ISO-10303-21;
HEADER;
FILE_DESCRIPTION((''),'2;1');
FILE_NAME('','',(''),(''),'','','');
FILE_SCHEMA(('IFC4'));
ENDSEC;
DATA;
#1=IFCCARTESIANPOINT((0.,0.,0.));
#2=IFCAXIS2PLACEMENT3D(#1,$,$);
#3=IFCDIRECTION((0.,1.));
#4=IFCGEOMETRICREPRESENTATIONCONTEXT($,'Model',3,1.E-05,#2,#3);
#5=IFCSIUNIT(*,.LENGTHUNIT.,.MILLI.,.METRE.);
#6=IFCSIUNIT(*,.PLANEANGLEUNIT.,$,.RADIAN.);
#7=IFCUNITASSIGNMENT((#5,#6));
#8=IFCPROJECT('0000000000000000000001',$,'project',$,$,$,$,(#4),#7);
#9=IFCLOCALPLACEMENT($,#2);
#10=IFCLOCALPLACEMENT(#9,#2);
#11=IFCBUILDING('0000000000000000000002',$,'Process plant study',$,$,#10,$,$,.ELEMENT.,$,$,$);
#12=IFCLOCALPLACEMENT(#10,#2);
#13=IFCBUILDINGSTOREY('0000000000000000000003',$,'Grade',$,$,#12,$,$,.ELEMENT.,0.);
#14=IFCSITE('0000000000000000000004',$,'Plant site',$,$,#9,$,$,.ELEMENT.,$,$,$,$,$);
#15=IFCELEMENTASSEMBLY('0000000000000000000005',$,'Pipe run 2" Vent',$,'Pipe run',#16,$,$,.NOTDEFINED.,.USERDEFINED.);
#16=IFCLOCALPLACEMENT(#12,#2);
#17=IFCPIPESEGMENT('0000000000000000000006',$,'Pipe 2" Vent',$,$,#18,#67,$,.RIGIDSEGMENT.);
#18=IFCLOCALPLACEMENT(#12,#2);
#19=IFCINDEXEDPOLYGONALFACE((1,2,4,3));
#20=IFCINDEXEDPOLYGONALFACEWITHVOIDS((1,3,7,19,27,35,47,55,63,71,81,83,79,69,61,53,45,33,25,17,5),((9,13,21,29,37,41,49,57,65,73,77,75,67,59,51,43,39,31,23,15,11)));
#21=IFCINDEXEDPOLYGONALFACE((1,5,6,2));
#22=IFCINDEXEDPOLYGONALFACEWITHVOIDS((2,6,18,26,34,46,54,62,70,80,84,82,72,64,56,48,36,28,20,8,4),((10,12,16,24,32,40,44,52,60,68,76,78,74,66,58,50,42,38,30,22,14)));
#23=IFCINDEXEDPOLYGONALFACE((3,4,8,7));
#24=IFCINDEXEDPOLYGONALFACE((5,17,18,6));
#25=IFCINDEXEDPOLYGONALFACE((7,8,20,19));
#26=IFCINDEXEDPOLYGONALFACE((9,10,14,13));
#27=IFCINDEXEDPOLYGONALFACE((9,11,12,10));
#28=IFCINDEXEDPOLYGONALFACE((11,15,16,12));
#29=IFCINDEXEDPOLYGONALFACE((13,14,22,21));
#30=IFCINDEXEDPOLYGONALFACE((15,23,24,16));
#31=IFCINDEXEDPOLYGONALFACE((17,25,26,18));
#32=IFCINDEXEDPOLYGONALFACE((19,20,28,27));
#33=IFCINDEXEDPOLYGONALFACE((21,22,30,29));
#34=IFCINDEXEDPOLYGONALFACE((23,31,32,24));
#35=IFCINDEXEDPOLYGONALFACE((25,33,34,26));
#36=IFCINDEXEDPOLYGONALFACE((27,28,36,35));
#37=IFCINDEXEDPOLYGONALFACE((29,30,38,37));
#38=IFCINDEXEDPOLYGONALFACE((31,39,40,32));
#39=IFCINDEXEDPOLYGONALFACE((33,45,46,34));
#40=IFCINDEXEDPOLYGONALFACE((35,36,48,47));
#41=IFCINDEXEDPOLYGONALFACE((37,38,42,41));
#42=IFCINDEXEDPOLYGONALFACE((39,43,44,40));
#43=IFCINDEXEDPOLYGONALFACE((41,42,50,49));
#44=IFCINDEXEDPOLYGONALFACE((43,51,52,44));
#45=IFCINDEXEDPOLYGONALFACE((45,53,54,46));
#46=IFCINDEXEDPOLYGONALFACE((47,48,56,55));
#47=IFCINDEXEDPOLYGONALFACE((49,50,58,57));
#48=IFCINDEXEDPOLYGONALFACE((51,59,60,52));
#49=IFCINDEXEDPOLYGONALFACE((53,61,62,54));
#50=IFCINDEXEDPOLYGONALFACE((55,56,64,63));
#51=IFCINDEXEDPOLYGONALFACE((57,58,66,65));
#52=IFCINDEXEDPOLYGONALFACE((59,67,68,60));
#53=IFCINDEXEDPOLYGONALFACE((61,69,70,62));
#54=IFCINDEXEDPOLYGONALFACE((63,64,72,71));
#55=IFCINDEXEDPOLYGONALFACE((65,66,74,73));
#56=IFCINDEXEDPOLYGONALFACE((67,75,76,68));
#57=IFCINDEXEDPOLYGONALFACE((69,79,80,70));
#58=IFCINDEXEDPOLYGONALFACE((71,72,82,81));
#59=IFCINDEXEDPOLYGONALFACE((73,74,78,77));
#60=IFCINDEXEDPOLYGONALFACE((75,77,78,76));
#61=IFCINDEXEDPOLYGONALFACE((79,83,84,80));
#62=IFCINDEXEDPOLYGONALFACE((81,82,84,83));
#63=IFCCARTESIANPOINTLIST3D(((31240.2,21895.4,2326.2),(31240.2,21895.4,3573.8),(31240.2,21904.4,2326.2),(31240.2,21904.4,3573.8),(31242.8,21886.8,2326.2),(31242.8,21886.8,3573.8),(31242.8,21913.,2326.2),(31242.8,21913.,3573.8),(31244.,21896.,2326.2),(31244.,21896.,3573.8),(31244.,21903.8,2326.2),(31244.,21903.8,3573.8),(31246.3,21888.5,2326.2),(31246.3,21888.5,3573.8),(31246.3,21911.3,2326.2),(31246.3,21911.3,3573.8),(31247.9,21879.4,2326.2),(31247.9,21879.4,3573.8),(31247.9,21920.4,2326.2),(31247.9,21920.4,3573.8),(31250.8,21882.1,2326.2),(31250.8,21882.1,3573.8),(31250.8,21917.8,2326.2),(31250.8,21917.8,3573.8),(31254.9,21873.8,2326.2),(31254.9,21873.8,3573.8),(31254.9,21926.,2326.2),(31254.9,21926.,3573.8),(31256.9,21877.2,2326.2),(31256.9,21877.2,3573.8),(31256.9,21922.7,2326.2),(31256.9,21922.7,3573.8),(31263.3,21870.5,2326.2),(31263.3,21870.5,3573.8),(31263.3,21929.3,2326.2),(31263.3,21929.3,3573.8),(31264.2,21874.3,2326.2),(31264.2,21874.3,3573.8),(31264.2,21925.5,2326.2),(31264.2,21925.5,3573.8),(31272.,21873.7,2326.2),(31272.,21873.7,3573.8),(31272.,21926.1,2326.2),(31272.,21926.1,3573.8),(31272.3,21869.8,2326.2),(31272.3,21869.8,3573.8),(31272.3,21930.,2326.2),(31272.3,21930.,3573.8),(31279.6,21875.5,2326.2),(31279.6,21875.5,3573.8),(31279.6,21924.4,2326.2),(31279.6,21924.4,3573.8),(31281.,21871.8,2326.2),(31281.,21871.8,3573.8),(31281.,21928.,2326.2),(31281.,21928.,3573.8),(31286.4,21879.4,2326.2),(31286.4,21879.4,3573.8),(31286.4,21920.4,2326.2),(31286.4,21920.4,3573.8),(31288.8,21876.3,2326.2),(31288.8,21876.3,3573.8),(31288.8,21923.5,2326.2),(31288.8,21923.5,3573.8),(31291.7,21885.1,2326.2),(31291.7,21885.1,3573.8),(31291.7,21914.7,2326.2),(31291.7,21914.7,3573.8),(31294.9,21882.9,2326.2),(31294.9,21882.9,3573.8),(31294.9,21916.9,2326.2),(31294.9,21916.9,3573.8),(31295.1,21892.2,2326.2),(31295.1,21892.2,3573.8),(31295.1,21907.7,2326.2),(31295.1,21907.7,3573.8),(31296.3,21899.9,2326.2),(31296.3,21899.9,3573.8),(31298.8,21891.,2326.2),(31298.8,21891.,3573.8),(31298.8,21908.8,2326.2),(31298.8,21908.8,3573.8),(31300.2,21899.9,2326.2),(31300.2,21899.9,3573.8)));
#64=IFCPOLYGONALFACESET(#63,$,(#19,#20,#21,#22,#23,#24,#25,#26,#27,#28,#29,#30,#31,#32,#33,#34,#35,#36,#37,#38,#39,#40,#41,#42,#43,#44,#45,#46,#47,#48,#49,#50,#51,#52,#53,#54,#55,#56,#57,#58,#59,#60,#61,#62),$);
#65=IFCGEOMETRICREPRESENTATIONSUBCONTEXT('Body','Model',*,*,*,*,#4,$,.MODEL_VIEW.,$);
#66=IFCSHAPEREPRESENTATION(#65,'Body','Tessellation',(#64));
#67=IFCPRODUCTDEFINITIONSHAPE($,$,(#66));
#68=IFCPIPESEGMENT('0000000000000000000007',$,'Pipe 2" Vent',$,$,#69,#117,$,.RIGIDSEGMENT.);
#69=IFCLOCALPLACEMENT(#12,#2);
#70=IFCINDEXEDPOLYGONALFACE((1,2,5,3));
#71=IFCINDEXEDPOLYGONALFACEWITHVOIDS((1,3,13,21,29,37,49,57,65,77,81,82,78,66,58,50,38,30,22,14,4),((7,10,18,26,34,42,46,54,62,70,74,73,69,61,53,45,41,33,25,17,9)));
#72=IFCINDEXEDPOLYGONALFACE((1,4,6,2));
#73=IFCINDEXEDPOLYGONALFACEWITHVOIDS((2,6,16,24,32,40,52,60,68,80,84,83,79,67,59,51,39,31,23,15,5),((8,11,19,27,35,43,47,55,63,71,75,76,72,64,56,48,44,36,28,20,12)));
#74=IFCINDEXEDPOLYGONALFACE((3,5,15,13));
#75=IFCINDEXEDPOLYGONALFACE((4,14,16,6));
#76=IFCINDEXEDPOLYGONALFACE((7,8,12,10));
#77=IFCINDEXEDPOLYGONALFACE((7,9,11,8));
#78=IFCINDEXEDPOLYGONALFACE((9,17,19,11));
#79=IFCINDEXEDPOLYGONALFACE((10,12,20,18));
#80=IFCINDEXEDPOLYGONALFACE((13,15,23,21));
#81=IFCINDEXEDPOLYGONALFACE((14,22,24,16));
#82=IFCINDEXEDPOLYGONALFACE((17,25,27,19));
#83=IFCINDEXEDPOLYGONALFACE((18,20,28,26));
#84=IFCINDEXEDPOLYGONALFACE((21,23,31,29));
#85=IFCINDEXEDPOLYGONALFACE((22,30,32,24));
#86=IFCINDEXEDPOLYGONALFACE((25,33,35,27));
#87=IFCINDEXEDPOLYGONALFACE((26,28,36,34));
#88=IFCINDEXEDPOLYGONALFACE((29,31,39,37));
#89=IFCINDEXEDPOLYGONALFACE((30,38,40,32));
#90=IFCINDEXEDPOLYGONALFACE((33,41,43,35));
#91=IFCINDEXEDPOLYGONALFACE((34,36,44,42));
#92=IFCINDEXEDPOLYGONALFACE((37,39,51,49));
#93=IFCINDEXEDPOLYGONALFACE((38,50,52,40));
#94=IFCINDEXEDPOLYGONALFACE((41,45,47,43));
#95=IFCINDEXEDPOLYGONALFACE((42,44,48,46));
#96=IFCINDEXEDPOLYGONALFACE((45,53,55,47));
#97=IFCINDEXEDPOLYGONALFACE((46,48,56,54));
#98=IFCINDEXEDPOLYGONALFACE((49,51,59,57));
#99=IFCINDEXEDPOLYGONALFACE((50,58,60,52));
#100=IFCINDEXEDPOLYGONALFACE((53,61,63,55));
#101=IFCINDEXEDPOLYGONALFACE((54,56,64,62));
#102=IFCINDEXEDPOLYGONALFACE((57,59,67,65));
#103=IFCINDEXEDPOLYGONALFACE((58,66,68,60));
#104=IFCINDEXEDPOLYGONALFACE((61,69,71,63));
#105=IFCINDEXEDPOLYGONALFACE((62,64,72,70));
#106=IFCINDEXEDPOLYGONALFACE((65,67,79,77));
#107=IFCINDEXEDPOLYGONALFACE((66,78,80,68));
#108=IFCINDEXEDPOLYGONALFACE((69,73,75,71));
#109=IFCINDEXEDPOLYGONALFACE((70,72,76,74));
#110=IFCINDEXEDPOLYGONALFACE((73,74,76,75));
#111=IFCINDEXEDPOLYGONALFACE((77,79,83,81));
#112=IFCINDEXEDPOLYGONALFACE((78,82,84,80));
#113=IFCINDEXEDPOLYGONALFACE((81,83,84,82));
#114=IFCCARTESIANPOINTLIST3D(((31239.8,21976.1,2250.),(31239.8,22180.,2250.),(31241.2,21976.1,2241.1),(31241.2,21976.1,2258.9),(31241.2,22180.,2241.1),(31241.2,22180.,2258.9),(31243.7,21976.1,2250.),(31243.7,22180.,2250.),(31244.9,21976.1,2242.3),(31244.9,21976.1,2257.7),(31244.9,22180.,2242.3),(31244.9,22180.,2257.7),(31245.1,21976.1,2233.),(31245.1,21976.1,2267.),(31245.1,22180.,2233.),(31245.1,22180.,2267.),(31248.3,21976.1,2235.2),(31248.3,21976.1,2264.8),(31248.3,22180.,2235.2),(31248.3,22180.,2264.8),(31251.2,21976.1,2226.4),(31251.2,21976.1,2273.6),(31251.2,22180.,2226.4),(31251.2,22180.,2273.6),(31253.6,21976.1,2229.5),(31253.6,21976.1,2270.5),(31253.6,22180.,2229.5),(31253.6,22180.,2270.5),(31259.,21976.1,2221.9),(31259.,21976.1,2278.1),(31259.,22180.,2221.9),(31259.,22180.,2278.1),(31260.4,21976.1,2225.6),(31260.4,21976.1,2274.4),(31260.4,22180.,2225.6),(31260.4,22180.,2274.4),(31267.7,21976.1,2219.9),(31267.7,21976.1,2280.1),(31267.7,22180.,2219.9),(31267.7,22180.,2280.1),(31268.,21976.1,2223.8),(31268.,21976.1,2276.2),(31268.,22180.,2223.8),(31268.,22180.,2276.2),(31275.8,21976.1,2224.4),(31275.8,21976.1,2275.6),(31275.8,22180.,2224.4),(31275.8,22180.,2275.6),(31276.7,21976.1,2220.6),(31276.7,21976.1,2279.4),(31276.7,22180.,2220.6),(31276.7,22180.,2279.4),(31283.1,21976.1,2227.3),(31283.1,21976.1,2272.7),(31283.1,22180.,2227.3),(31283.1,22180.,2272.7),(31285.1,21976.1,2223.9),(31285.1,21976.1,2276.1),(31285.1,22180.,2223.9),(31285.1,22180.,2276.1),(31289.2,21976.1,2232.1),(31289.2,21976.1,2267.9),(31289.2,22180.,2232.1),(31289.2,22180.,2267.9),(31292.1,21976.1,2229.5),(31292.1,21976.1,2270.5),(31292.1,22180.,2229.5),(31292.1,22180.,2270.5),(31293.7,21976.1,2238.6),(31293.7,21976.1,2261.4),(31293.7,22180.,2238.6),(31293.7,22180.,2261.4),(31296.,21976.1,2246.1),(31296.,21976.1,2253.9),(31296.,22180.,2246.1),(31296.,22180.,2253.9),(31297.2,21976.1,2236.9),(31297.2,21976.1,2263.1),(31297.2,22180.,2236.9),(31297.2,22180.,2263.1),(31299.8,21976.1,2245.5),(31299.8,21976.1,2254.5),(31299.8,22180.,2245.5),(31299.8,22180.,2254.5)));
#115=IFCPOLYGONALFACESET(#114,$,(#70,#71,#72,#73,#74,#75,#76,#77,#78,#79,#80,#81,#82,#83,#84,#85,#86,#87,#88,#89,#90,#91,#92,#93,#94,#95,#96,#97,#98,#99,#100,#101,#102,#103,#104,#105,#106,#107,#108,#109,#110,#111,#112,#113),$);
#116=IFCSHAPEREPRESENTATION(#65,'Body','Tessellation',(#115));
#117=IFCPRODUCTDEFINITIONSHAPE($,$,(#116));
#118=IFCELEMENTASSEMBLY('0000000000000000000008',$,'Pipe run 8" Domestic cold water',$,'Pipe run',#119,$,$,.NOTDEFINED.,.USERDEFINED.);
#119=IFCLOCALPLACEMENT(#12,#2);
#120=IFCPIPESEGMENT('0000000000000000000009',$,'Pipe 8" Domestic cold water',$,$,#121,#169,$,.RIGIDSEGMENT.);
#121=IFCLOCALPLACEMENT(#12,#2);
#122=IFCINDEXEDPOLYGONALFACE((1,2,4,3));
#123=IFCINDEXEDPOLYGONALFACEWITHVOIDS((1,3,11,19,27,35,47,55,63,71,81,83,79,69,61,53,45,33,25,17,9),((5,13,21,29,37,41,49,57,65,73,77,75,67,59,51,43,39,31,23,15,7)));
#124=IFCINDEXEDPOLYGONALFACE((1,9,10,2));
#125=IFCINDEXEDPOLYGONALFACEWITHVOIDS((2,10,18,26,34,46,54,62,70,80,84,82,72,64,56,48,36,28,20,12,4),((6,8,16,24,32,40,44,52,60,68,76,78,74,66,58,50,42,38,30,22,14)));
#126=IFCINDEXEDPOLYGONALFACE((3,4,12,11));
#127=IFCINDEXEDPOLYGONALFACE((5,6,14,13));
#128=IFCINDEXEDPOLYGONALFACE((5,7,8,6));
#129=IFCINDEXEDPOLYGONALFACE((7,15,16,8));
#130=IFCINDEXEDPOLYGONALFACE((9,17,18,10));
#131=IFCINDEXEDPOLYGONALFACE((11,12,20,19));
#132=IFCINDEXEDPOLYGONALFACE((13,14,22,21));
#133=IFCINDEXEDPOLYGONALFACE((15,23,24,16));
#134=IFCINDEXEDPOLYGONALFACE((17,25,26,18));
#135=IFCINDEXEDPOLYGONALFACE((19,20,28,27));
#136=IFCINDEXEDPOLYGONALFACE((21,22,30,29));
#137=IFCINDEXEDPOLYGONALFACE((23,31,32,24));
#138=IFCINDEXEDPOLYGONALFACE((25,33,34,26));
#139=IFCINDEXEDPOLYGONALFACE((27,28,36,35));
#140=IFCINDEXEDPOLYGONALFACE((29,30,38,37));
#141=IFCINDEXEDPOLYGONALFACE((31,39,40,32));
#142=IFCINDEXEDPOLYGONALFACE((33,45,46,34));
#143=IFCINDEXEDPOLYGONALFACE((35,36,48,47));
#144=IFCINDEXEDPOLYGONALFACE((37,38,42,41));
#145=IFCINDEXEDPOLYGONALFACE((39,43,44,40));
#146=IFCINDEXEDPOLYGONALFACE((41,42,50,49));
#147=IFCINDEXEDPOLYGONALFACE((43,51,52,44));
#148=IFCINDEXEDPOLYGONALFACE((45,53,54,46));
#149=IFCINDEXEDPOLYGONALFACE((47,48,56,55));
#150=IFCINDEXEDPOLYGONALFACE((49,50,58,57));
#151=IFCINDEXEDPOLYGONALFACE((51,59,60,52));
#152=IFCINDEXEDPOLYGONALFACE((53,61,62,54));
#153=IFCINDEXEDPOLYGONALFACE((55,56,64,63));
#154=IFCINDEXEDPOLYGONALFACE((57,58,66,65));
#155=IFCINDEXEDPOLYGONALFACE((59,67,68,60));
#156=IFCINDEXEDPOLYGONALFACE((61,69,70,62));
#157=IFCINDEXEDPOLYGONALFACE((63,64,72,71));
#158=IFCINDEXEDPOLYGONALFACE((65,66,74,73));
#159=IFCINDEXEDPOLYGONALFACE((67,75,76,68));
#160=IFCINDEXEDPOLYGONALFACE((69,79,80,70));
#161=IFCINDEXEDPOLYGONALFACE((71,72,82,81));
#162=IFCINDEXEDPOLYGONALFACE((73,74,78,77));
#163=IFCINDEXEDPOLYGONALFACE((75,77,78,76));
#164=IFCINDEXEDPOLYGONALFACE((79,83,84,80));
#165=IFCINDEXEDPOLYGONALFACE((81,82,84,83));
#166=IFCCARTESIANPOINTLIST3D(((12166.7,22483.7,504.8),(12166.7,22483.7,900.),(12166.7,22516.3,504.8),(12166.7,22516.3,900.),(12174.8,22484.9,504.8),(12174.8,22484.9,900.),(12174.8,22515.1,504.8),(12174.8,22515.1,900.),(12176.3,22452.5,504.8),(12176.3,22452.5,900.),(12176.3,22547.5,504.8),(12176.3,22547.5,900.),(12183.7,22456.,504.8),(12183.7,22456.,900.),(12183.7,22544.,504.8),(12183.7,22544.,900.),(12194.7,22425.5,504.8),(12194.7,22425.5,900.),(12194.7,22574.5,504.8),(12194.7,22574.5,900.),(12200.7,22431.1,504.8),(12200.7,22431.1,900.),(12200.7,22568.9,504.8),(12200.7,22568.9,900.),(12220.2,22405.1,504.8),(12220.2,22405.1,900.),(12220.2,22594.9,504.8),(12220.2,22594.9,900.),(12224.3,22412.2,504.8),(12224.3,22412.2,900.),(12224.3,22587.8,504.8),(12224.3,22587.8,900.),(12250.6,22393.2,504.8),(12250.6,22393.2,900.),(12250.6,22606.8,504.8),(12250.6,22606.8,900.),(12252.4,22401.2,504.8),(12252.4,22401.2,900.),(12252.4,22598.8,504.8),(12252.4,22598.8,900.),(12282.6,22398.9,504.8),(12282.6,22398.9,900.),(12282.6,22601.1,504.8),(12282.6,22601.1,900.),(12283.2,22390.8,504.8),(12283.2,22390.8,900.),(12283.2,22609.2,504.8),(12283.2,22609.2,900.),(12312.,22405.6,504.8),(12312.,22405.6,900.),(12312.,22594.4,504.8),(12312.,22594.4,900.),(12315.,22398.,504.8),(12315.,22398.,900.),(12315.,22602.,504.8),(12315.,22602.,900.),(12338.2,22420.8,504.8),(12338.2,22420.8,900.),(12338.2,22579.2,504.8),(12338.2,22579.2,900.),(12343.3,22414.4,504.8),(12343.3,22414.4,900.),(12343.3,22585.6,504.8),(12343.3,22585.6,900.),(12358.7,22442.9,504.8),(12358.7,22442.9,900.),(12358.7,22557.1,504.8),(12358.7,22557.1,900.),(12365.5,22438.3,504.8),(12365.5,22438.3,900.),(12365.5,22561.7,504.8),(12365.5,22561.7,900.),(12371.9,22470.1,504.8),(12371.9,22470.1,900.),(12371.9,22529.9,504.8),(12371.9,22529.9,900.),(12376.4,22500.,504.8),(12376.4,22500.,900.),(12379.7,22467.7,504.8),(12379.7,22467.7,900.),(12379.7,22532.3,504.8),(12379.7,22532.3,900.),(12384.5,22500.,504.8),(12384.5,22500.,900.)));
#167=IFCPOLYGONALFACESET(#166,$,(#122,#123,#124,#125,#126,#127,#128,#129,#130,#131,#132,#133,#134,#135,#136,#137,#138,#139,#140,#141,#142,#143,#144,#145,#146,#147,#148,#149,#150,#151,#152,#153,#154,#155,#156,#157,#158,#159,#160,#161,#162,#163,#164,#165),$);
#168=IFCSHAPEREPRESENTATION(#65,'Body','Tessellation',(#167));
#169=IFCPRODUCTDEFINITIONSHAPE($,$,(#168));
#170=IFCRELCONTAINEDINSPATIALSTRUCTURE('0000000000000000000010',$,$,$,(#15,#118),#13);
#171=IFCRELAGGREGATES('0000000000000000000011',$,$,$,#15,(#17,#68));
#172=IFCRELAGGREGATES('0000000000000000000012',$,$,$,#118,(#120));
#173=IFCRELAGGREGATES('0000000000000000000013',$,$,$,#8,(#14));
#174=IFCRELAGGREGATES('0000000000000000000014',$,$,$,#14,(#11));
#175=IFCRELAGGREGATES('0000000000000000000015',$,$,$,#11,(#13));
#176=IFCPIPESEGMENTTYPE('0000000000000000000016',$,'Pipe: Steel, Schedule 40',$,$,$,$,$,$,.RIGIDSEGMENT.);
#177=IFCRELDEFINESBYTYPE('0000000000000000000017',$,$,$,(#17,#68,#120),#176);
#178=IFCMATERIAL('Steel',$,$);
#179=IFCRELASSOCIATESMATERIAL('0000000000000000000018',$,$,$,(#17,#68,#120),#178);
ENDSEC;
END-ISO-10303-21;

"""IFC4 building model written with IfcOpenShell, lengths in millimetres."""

from ifc_helpers import new_model, si_unit, direction, frame, origin, origin_with_axes, origin_2d, place, context, subcontext, project, spatial, hollow_circle, extrude, material, type_object, element, aggregate, save


model = new_model("IFC4")

# Units and contexts
model_context = context("Model", 3, precision=1e-05, world=origin(), true_north=direction((0.0, 1.0)))
body_context = subcontext(model_context, "Body", "Model", "MODEL_VIEW")
ifc_project = project(units=[si_unit("LENGTHUNIT", "METRE", prefix="MILLI"), si_unit("PLANEANGLEUNIT", "RADIAN")], contexts=[model_context])

# Site, building, storey
site_placement = place(None, origin())
site = spatial("IfcSite", under=ifc_project, at=site_placement, Name="Plant site", CompositionType="ELEMENT")
building_placement = place(site_placement, origin())
building = spatial("IfcBuilding", under=site, at=building_placement, Name="Process plant study", CompositionType="ELEMENT")
storey_placement = place(building_placement, origin())
storey = spatial("IfcBuildingStorey", under=building, at=storey_placement, Name="Grade", CompositionType="ELEMENT", Elevation=0.0)

# Element assemblies, pipe segments
ifc_material = material(Name="Steel")
pipe_segment_type = type_object("IfcPipeSegmentType", Name="Pipe: Steel, Schedule 40", PredefinedType="RIGIDSEGMENT")
assembly_1_placement = place(storey_placement, origin_with_axes())
assembly_1 = element("IfcElementAssembly", 1, at=assembly_1_placement, inside=storey, Name="Pipe run 2\" Vent", ObjectType="Pipe run", AssemblyPlace="NOTDEFINED", PredefinedType="USERDEFINED")
pipe_segment_1_placement = place(storey_placement, origin_with_axes())
pipe_segment_1 = element("IfcPipeSegment", 2, at=pipe_segment_1_placement, type_object=pipe_segment_type, material=ifc_material, Name="Pipe 2\" Vent", PredefinedType="RIGIDSEGMENT", context=body_context, shape_type="SweptSolid", body=[
    extrude(hollow_circle(Radius=30.2, WallThickness=3.9, at=origin_2d()), frame((31270.0, 21899.9, 3573.8), z_axis=(0.0, 0.0, -1.0), x_axis=(1.0, 0.0, 0.0)), (0.0, 0.0, 1.0), 1247.6),
])
pipe_segment_2_placement = place(storey_placement, origin_with_axes())
pipe_segment_2 = element("IfcPipeSegment", 3, at=pipe_segment_2_placement, type_object=pipe_segment_type, material=ifc_material, Name="Pipe 2\" Vent", PredefinedType="RIGIDSEGMENT", context=body_context, shape_type="SweptSolid", body=[
    extrude(hollow_circle(Radius=30.2, WallThickness=3.9, at=origin_2d()), frame((31270.0, 21976.1, 2250.0), z_axis=(0.0, 1.0, 0.0), x_axis=(-1.0, 0.0, 0.0)), (0.0, 0.0, 1.0), 203.9),
])
assembly_2_placement = place(storey_placement, origin_with_axes())
assembly_2 = element("IfcElementAssembly", 4, at=assembly_2_placement, inside=storey, Name="Pipe run 8\" Domestic cold water", ObjectType="Pipe run", AssemblyPlace="NOTDEFINED", PredefinedType="USERDEFINED")
pipe_segment_3_placement = place(storey_placement, origin_with_axes())
pipe_segment_3 = element("IfcPipeSegment", 5, at=pipe_segment_3_placement, type_object=pipe_segment_type, material=ifc_material, Name="Pipe 8\" Domestic cold water", PredefinedType="RIGIDSEGMENT", context=body_context, shape_type="SweptSolid", body=[
    extrude(hollow_circle(Radius=109.5, WallThickness=8.2, at=origin_2d()), frame((12275.0, 22500.0, 900.0), z_axis=(0.0, 0.0, -1.0), x_axis=(1.0, 0.0, 0.0)), (0.0, 0.0, 1.0), 395.2),
])

aggregate(assembly_1, [pipe_segment_1, pipe_segment_2])
aggregate(assembly_2, [pipe_segment_3])

save(model, "model.ifc")
